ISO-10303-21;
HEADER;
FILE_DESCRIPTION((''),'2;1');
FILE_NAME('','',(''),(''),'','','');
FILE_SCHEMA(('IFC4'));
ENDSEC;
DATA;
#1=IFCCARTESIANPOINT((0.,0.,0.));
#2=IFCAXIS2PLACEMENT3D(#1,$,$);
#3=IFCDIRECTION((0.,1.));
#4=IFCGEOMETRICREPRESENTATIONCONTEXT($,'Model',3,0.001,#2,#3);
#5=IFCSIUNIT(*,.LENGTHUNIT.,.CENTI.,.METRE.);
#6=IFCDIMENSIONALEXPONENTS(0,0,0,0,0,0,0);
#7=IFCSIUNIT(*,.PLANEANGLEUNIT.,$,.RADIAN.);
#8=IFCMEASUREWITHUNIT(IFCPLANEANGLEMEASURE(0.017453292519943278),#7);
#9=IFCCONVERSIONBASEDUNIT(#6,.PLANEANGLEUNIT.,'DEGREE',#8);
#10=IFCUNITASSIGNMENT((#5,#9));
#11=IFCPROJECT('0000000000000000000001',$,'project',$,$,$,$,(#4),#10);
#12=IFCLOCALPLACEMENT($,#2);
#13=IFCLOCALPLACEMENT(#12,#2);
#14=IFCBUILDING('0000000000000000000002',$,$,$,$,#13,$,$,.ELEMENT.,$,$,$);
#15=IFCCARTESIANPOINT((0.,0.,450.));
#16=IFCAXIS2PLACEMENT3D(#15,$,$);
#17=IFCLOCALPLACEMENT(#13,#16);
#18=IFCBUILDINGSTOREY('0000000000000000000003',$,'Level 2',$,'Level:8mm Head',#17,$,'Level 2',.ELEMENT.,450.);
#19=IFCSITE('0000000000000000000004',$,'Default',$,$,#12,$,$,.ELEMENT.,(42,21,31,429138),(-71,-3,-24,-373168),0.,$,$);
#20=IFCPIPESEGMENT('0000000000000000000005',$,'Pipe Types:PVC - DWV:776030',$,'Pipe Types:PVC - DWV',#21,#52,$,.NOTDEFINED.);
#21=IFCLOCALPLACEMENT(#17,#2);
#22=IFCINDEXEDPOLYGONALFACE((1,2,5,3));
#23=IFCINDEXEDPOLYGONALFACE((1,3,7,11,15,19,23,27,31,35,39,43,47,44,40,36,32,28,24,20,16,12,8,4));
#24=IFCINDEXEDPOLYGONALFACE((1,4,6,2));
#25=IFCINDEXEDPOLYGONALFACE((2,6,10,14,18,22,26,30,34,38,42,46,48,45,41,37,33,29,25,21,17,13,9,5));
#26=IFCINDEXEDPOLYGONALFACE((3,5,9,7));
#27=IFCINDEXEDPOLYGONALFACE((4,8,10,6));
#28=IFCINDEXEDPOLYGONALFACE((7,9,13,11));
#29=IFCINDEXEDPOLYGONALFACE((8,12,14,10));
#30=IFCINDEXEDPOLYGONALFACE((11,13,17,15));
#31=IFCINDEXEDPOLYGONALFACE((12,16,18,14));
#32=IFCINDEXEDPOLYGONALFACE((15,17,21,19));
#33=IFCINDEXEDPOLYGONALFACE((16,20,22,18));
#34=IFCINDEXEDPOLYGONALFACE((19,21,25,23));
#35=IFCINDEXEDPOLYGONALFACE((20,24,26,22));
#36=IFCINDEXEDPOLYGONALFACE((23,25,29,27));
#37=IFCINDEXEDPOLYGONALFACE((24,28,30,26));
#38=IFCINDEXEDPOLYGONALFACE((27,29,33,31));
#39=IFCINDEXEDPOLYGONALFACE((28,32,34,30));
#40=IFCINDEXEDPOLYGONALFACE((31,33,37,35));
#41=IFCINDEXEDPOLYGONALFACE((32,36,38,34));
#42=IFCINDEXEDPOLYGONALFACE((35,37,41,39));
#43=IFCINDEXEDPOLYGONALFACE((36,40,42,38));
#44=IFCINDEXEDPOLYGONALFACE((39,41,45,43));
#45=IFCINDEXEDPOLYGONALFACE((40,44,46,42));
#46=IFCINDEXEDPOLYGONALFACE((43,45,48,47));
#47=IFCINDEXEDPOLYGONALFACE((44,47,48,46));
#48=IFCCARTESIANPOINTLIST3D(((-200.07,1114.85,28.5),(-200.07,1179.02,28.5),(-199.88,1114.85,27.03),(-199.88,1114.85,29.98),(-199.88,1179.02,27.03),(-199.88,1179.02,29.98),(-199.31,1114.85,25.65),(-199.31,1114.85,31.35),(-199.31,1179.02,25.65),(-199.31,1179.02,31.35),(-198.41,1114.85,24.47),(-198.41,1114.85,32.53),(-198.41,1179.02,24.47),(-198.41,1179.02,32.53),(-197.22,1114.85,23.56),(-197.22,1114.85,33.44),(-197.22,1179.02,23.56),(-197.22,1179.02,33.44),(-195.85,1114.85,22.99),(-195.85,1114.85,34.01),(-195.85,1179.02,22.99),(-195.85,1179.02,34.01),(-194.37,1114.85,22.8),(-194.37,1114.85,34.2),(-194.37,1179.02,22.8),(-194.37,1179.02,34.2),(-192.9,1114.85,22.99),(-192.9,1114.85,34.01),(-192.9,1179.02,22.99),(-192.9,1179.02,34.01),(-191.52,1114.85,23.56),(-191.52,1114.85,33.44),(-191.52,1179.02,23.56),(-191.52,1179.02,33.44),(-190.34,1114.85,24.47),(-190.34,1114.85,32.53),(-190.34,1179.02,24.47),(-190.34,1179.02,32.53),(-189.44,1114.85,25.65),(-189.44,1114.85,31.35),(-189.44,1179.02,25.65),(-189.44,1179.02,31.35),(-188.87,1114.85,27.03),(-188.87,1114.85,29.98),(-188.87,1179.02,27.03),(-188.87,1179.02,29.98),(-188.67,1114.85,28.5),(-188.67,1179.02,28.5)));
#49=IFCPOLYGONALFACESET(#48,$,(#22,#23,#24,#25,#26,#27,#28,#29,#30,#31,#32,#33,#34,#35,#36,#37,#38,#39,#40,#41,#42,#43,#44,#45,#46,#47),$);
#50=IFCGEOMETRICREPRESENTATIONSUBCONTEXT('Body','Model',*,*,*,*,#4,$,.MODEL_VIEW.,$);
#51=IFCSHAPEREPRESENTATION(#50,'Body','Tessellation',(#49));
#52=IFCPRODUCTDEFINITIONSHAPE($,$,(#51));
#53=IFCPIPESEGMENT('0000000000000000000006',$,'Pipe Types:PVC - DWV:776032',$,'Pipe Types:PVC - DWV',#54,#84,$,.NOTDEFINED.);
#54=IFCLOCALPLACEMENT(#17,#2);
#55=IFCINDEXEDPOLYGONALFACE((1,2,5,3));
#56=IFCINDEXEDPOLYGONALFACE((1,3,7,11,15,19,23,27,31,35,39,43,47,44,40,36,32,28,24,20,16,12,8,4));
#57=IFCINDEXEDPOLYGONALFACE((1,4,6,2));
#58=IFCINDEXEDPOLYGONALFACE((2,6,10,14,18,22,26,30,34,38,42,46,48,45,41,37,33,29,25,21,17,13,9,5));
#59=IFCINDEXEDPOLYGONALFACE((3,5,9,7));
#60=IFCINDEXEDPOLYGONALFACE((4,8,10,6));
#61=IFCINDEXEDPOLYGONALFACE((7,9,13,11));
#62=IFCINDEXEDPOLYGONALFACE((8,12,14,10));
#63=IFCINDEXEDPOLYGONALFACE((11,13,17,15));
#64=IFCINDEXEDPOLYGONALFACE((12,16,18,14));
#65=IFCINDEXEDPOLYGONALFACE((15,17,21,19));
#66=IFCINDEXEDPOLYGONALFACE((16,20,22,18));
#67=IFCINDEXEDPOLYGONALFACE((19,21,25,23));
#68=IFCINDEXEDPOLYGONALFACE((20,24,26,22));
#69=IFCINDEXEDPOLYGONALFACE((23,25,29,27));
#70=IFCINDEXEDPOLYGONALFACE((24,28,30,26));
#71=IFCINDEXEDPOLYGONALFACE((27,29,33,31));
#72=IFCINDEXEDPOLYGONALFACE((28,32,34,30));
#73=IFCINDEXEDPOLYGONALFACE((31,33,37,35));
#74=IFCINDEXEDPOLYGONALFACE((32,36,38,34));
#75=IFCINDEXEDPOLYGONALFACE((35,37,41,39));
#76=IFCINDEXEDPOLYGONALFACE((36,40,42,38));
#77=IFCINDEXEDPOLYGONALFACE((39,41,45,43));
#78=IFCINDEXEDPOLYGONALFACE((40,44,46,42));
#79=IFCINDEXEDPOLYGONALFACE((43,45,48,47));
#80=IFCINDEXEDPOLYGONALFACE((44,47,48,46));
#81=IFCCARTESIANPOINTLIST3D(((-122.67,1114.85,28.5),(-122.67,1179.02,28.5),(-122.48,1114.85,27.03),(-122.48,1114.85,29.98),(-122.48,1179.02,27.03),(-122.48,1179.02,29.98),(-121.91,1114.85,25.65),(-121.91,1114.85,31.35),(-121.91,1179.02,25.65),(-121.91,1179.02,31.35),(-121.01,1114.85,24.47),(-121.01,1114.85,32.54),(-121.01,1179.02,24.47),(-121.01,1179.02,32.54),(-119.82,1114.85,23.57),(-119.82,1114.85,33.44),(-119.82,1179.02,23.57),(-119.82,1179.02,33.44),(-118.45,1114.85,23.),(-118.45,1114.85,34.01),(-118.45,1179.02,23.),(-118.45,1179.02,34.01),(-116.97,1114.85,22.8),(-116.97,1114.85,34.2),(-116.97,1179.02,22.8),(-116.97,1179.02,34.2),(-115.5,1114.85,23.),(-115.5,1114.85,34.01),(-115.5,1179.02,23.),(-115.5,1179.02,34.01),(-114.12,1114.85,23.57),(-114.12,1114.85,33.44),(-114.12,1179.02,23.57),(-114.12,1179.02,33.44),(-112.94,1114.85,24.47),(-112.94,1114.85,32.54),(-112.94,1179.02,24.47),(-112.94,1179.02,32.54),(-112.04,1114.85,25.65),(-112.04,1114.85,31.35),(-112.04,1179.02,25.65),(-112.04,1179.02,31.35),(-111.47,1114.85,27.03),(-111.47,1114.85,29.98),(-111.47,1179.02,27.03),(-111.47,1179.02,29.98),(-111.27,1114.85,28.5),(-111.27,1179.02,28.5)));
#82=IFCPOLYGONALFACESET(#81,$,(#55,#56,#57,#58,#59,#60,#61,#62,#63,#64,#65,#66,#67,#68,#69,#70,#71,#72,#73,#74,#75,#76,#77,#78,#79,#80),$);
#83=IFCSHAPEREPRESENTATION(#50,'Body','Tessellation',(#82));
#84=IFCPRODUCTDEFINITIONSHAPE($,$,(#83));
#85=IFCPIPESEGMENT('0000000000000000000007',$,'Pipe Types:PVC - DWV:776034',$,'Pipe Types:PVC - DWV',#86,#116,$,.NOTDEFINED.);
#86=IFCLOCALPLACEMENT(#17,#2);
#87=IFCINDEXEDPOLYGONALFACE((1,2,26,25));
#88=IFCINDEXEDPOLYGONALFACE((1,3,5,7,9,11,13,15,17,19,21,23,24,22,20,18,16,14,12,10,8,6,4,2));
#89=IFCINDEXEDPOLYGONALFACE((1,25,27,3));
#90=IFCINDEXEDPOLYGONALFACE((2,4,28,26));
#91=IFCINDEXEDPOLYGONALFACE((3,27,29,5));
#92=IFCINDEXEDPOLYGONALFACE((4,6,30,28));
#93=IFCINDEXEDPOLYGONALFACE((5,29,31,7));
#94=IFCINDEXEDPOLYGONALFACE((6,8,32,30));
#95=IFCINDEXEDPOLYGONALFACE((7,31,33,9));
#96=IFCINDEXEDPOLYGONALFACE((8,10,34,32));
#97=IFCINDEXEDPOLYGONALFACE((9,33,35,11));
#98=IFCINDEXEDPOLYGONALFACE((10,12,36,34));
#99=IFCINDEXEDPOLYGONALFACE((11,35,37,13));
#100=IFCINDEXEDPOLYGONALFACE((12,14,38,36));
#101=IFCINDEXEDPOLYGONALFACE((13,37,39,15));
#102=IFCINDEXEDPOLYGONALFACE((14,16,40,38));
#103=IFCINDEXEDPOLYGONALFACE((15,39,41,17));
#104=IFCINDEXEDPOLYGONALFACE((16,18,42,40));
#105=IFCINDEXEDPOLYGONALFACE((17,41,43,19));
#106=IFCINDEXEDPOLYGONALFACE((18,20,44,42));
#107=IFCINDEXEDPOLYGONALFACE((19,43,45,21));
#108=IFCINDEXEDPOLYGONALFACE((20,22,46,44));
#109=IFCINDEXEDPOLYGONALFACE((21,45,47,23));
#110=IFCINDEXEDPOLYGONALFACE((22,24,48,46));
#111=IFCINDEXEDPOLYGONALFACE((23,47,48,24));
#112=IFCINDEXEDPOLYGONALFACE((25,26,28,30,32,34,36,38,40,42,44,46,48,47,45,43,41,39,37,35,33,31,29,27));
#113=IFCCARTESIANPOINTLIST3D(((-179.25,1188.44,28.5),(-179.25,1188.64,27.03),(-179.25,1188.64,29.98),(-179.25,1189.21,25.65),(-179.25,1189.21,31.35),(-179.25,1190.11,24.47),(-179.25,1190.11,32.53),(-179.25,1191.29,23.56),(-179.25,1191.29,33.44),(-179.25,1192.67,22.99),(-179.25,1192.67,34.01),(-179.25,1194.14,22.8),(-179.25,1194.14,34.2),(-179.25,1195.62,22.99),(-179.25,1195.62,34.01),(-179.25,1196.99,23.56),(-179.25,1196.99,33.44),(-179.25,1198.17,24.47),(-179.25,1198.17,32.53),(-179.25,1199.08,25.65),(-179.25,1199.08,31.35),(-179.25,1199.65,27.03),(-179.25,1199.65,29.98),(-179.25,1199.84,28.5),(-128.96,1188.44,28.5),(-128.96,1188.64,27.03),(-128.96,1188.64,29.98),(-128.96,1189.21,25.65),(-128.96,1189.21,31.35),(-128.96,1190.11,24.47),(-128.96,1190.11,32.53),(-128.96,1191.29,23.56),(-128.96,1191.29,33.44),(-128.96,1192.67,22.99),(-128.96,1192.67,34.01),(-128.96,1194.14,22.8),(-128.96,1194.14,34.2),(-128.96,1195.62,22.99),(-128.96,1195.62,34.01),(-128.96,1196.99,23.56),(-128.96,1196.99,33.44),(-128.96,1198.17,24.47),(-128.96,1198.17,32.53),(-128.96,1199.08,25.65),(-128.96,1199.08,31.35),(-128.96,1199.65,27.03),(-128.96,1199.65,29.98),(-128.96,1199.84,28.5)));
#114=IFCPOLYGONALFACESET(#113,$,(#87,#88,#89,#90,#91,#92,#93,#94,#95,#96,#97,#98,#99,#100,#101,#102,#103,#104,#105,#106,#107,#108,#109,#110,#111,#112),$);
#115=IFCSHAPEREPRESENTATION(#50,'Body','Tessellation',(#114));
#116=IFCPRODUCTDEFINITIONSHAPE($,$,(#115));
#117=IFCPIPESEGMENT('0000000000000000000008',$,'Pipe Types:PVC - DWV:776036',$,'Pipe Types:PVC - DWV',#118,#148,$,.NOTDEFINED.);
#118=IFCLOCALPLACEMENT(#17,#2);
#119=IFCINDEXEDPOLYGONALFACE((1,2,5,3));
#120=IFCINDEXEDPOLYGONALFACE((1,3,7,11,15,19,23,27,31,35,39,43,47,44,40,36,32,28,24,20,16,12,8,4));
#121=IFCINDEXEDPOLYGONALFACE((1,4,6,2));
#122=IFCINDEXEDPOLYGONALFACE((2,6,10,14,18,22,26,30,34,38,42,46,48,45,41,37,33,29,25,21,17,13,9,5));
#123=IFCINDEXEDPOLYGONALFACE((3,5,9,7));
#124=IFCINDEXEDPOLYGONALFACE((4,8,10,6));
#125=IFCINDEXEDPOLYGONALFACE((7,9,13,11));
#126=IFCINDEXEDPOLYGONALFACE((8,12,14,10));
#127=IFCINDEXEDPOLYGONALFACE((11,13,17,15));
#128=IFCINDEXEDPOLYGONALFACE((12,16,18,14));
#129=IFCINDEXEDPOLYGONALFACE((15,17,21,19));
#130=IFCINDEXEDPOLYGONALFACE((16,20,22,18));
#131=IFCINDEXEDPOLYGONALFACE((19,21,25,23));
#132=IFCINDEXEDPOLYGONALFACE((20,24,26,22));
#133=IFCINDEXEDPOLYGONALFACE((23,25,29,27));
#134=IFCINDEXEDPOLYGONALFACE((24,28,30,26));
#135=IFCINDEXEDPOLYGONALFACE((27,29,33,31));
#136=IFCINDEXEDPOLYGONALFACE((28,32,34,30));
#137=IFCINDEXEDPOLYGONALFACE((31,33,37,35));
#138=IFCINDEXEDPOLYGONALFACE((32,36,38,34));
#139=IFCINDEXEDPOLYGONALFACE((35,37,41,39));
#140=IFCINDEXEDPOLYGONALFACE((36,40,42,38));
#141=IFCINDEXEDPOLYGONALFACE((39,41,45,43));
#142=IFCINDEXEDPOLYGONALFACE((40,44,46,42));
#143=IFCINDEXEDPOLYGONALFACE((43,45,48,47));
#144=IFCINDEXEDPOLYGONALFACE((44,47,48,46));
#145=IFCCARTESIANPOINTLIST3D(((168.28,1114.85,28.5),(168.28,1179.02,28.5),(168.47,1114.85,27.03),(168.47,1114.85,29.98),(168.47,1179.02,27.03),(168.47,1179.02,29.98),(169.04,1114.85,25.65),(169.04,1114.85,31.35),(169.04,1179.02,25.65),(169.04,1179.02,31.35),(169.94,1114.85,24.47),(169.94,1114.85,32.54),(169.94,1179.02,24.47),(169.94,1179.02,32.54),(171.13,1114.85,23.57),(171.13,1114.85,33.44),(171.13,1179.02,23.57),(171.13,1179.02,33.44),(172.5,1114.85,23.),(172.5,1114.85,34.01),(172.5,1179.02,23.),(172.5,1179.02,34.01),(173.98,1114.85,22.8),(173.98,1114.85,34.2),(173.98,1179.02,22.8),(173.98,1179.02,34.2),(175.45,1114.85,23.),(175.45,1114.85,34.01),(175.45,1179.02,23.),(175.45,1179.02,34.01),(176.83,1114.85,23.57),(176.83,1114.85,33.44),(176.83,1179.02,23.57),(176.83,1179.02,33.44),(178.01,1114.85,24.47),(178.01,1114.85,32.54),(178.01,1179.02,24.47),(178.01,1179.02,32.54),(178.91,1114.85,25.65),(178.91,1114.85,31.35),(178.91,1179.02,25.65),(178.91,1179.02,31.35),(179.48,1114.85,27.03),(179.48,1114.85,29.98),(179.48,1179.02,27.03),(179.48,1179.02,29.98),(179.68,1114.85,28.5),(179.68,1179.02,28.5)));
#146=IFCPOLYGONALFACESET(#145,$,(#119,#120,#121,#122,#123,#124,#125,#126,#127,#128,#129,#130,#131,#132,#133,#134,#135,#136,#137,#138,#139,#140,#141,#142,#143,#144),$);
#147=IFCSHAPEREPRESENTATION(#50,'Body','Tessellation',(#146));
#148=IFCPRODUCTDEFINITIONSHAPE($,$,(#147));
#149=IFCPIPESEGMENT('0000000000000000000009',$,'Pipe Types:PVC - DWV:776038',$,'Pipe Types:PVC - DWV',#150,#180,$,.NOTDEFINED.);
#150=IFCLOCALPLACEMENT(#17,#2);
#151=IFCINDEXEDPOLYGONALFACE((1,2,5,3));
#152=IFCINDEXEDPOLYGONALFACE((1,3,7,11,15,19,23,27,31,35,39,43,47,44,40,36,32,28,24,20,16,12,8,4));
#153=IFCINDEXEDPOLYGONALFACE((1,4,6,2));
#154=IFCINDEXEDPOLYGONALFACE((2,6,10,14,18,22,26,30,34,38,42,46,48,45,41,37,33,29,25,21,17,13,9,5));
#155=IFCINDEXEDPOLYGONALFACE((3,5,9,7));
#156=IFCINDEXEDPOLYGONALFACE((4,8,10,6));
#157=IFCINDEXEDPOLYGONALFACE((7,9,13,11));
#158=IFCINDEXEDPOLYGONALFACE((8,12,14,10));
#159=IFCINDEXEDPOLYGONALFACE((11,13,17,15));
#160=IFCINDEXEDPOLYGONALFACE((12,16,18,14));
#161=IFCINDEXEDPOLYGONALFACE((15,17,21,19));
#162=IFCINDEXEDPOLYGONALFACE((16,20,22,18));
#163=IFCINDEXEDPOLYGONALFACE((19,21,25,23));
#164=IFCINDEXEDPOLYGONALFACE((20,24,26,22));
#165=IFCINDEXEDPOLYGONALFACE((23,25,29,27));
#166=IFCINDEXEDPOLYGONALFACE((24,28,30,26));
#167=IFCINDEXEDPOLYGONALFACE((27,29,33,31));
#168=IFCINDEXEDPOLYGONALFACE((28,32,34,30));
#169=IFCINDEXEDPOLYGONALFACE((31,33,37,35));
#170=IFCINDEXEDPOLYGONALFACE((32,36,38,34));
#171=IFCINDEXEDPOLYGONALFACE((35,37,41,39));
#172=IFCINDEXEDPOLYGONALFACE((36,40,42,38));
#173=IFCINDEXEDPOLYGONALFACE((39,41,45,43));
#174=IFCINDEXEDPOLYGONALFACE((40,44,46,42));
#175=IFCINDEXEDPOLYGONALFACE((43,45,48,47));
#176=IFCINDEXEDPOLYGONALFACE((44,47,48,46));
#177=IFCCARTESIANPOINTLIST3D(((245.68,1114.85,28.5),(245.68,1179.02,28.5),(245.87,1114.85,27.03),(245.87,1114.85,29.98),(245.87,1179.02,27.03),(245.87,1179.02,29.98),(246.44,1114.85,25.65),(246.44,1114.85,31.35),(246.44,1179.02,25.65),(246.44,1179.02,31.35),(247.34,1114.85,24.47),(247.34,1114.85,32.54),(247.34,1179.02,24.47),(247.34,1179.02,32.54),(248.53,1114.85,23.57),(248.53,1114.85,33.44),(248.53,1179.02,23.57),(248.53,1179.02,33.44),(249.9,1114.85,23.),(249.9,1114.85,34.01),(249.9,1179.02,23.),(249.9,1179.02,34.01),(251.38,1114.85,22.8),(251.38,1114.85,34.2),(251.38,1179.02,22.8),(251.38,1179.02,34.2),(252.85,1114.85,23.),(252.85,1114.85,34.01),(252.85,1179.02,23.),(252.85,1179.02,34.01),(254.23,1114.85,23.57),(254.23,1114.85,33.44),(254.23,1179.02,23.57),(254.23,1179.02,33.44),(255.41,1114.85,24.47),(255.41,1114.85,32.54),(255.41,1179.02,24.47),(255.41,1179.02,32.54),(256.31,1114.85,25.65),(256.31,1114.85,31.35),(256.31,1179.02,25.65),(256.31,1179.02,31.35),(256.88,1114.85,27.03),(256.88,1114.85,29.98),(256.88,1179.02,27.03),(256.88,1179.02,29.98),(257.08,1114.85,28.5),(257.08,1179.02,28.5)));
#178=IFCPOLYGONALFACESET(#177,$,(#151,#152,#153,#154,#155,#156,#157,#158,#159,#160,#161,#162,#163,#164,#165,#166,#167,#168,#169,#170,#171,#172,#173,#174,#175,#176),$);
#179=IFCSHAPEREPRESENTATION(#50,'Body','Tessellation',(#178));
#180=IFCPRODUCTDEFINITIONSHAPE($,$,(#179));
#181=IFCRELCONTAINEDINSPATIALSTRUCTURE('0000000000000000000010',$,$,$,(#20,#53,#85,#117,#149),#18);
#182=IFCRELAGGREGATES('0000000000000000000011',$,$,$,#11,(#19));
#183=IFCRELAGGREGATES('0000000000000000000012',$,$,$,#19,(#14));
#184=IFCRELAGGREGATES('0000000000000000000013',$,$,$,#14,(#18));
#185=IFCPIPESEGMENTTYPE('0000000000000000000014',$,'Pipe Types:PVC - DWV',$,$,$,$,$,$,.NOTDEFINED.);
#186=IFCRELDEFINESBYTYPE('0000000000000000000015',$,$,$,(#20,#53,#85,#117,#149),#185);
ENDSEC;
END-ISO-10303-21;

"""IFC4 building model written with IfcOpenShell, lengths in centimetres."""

from ifc_helpers import new_model, entity, si_unit, converted_unit, direction, frame, origin, place, context, subcontext, project, spatial, arc, indexed_curve, outline, extrude, type_object, element, save


model = new_model("IFC4")

# Units and contexts
model_context = context("Model", 3, precision=0.001, world=origin(), true_north=direction((0.0, 1.0)))
body_context = subcontext(model_context, "Body", "Model", "MODEL_VIEW")
ifc_project = project(units=[si_unit("LENGTHUNIT", "METRE", prefix="CENTI"), converted_unit("PLANEANGLEUNIT", "DEGREE", entity("IfcPlaneAngleMeasure", 0.017453292519943278), si_unit("PLANEANGLEUNIT", "RADIAN"), dimensions=[0, 0, 0, 0, 0, 0, 0])], contexts=[model_context])

# Site, building, storey
site_placement = place(None, origin())
site = spatial("IfcSite", under=ifc_project, at=site_placement, Name="Default", CompositionType="ELEMENT", RefLatitude=(42, 21, 31, 429138), RefLongitude=(-71, -3, -24, -373168), RefElevation=0.0)
building_placement = place(site_placement, origin())
building = spatial("IfcBuilding", under=site, at=building_placement, CompositionType="ELEMENT")
storey_placement = place(building_placement, frame((0.0, 0.0, 450.0)))
storey = spatial("IfcBuildingStorey", under=building, at=storey_placement, Name="Level 2", ObjectType="Level:8mm Head", LongName="Level 2", CompositionType="ELEMENT", Elevation=450.0)

# Pipe segments
pipe_segment_type = type_object("IfcPipeSegmentType", Name="Pipe Types:PVC - DWV", PredefinedType="NOTDEFINED")
pipe_segment_1_placement = place(storey_placement, origin())
element("IfcPipeSegment", 1, at=pipe_segment_1_placement, inside=storey, type_object=pipe_segment_type, Name="Pipe Types:PVC - DWV:776030", ObjectType="Pipe Types:PVC - DWV", PredefinedType="NOTDEFINED", context=body_context, shape_type="SweptSolid", body=[
    extrude(outline(indexed_curve([(5.7, 0.0), (4.03, 4.03), (0.0, 5.7), (-4.03, 4.03), (-5.7, 0.0), (-4.03, -4.03), (0.0, -5.7), (4.03, -4.03)], segments=[arc(1, 2, 3), arc(3, 4, 5), arc(5, 6, 7), arc(7, 8, 1)], self_intersect=False)), frame((-194.37, 1114.85, 28.5), z_axis=(0.0, 1.0, 0.0), x_axis=(-1.0, 0.0, 0.0)), (0.0, 0.0, 1.0), 64.18),
])
pipe_segment_2_placement = place(storey_placement, origin())
element("IfcPipeSegment", 2, at=pipe_segment_2_placement, inside=storey, type_object=pipe_segment_type, Name="Pipe Types:PVC - DWV:776032", ObjectType="Pipe Types:PVC - DWV", PredefinedType="NOTDEFINED", context=body_context, shape_type="SweptSolid", body=[
    extrude(outline(indexed_curve([(5.7, 0.0), (4.03, 4.03), (0.0, 5.7), (-4.03, 4.03), (-5.7, 0.0), (-4.03, -4.03), (0.0, -5.7), (4.03, -4.03)], segments=[arc(1, 2, 3), arc(3, 4, 5), arc(5, 6, 7), arc(7, 8, 1)], self_intersect=False)), frame((-116.97, 1114.85, 28.5), z_axis=(0.0, 1.0, 0.0), x_axis=(-1.0, 0.0, 0.0)), (0.0, 0.0, 1.0), 64.18),
])
pipe_segment_3_placement = place(storey_placement, origin())
element("IfcPipeSegment", 3, at=pipe_segment_3_placement, inside=storey, type_object=pipe_segment_type, Name="Pipe Types:PVC - DWV:776034", ObjectType="Pipe Types:PVC - DWV", PredefinedType="NOTDEFINED", context=body_context, shape_type="SweptSolid", body=[
    extrude(outline(indexed_curve([(5.7, 0.0), (4.03, 4.03), (0.0, 5.7), (-4.03, 4.03), (-5.7, 0.0), (-4.03, -4.03), (0.0, -5.7), (4.03, -4.03)], segments=[arc(1, 2, 3), arc(3, 4, 5), arc(5, 6, 7), arc(7, 8, 1)], self_intersect=False)), frame((-179.25, 1194.14, 28.5), z_axis=(1.0, 0.0, 0.0), x_axis=(0.0, 1.0, 0.0)), (0.0, 0.0, 1.0), 50.29),
])
pipe_segment_4_placement = place(storey_placement, origin())
element("IfcPipeSegment", 4, at=pipe_segment_4_placement, inside=storey, type_object=pipe_segment_type, Name="Pipe Types:PVC - DWV:776036", ObjectType="Pipe Types:PVC - DWV", PredefinedType="NOTDEFINED", context=body_context, shape_type="SweptSolid", body=[
    extrude(outline(indexed_curve([(5.7, 0.0), (4.03, 4.03), (0.0, 5.7), (-4.03, 4.03), (-5.7, 0.0), (-4.03, -4.03), (0.0, -5.7), (4.03, -4.03)], segments=[arc(1, 2, 3), arc(3, 4, 5), arc(5, 6, 7), arc(7, 8, 1)], self_intersect=False)), frame((173.98, 1114.85, 28.5), z_axis=(0.0, 1.0, 0.0), x_axis=(-1.0, 0.0, 0.0)), (0.0, 0.0, 1.0), 64.18),
])
pipe_segment_5_placement = place(storey_placement, origin())
element("IfcPipeSegment", 5, at=pipe_segment_5_placement, inside=storey, type_object=pipe_segment_type, Name="Pipe Types:PVC - DWV:776038", ObjectType="Pipe Types:PVC - DWV", PredefinedType="NOTDEFINED", context=body_context, shape_type="SweptSolid", body=[
    extrude(outline(indexed_curve([(5.7, 0.0), (4.03, 4.03), (0.0, 5.7), (-4.03, 4.03), (-5.7, 0.0), (-4.03, -4.03), (0.0, -5.7), (4.03, -4.03)], segments=[arc(1, 2, 3), arc(3, 4, 5), arc(5, 6, 7), arc(7, 8, 1)], self_intersect=False)), frame((251.38, 1114.85, 28.5), z_axis=(0.0, 1.0, 0.0), x_axis=(-1.0, 0.0, 0.0)), (0.0, 0.0, 1.0), 64.18),
])

save(model, "model.ifc")
